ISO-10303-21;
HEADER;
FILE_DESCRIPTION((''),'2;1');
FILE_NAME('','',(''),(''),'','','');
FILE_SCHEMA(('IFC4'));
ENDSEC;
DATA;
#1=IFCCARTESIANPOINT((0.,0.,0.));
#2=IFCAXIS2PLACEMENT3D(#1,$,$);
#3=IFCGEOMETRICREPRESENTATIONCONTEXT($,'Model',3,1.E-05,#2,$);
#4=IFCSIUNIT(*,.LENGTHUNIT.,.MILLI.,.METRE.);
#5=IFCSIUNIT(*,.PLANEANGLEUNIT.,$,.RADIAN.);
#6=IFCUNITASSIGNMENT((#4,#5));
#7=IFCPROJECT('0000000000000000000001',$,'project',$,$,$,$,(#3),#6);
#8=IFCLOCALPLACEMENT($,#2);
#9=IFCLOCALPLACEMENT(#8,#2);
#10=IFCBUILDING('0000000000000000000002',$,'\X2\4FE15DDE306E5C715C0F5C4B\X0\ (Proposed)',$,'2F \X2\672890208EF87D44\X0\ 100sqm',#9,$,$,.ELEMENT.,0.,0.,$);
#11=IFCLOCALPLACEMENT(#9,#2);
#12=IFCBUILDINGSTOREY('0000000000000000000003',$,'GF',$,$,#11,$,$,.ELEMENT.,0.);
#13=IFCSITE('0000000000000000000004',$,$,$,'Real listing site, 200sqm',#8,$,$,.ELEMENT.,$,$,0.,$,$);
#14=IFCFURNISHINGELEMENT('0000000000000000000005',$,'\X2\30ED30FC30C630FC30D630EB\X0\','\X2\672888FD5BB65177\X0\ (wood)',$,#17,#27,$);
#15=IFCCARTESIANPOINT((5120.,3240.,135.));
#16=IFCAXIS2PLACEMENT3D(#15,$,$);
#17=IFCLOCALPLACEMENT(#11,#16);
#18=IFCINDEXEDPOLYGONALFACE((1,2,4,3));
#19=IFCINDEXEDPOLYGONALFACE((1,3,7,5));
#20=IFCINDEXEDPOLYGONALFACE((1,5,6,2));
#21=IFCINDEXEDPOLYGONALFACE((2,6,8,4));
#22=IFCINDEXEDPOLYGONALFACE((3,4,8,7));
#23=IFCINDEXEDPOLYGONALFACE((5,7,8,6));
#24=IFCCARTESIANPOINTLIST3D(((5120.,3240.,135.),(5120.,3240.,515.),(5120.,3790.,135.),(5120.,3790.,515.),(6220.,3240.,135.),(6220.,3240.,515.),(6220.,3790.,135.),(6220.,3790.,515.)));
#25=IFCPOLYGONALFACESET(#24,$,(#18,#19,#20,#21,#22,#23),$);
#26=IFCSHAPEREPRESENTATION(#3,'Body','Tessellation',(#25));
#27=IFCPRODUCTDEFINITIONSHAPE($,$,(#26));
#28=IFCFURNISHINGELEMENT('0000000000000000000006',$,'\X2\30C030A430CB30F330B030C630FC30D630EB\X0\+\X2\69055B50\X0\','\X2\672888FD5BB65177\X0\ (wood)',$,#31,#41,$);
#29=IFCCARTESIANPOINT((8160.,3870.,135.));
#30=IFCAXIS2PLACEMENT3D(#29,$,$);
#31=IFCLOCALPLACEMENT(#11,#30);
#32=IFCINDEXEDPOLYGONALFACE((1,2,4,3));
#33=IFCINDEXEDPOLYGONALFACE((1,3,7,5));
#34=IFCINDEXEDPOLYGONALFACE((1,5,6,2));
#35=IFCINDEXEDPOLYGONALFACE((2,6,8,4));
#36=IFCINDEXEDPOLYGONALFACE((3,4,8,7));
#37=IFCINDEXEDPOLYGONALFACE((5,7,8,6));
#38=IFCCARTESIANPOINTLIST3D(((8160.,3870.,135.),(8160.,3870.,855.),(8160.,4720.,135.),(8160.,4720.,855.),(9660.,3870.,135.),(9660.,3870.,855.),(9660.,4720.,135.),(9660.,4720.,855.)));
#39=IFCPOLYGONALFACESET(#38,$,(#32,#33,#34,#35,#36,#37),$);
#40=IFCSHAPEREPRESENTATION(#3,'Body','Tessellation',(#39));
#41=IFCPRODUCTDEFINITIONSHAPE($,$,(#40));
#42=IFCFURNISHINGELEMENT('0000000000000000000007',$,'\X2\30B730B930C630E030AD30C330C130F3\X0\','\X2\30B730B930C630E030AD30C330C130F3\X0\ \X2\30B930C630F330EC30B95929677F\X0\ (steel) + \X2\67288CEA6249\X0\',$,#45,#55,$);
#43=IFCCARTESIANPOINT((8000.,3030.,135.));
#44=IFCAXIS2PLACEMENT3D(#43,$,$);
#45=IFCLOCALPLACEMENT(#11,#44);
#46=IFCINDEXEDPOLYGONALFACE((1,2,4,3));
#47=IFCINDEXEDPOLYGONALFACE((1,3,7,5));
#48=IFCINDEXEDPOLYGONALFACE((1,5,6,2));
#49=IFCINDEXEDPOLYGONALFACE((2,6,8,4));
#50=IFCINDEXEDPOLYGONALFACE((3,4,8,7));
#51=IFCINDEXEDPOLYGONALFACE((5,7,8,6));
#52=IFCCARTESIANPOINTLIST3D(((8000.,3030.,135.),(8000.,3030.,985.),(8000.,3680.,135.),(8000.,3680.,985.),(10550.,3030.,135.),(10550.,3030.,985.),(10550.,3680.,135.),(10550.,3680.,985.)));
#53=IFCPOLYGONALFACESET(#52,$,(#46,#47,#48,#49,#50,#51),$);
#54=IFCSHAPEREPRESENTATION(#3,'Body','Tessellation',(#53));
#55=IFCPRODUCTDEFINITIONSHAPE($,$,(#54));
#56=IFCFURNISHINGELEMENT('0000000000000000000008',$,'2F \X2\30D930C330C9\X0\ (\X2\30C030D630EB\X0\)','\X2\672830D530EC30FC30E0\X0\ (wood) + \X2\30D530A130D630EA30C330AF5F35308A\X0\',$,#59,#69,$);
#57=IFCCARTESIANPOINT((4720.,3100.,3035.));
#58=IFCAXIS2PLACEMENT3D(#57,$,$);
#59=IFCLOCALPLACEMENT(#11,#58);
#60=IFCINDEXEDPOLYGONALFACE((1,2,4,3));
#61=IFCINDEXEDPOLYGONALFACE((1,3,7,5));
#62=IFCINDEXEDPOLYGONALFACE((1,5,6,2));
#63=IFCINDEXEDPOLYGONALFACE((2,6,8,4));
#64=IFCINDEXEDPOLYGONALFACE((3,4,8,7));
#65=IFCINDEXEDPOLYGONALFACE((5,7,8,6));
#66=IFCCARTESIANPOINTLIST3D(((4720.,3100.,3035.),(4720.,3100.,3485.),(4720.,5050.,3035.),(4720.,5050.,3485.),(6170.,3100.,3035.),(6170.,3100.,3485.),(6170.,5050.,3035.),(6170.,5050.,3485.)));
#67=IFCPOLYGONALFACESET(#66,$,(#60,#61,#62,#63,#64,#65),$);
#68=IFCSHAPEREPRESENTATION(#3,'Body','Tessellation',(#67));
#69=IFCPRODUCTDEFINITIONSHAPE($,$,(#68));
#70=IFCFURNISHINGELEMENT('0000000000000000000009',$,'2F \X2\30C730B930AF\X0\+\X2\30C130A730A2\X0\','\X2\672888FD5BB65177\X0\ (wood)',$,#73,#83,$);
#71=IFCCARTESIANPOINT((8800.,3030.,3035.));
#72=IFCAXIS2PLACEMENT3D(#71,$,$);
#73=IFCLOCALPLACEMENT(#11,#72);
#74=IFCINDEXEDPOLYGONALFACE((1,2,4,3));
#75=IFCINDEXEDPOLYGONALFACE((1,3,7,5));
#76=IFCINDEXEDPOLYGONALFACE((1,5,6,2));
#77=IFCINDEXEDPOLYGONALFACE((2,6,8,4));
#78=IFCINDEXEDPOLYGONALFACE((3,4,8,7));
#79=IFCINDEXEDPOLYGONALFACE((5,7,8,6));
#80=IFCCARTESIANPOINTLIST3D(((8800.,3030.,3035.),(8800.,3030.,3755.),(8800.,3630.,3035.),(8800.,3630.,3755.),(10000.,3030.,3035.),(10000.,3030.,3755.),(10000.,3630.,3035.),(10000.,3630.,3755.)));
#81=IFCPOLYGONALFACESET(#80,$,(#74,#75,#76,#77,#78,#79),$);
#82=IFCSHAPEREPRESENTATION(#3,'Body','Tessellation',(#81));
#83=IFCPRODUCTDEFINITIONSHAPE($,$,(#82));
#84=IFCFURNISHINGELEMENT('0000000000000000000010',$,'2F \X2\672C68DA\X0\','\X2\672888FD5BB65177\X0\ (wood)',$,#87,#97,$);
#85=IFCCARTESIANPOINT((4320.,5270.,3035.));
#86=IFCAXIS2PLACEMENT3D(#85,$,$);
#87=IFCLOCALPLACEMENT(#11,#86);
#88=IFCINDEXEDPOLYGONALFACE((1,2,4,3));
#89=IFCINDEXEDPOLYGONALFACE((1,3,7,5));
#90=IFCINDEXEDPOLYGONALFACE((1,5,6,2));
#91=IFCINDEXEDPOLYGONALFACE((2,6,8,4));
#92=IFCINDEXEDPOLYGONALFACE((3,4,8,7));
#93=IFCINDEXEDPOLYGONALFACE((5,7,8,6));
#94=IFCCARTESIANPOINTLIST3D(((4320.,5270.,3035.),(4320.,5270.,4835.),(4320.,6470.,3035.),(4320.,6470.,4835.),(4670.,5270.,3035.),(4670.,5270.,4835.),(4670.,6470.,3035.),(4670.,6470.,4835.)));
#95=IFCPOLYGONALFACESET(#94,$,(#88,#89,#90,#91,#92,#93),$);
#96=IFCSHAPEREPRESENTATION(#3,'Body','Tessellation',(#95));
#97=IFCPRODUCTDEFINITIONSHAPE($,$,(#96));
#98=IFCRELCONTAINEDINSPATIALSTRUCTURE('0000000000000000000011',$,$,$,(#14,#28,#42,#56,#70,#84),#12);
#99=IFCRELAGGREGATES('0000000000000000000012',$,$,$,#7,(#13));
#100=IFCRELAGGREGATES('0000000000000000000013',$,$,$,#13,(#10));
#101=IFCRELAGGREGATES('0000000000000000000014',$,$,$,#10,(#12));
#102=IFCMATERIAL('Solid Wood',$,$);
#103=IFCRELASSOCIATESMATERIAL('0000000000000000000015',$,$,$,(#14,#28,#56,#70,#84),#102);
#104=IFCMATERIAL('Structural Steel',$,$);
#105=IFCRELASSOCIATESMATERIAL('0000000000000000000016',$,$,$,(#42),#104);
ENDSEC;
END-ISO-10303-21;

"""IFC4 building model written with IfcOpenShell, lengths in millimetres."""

from ifc_helpers import new_model, si_unit, frame, frame_2d, origin, place, context, project, spatial, rectangle, extrude, material, element, save


model = new_model("IFC4")

# Units and contexts
model_context = context("Model", 3, precision=1e-05, world=origin())
ifc_project = project(units=[si_unit("LENGTHUNIT", "METRE", prefix="MILLI"), si_unit("PLANEANGLEUNIT", "RADIAN")], contexts=[model_context])

# Site, building, storey
site_placement = place(None, origin())
site = spatial("IfcSite", under=ifc_project, at=site_placement, ObjectType="Real listing site, 200sqm", CompositionType="ELEMENT", RefElevation=0.0)
building_placement = place(site_placement, origin())
building = spatial("IfcBuilding", under=site, at=building_placement, Name="信州の山小屋 (Proposed)", ObjectType="2F 木造軸組 100sqm", CompositionType="ELEMENT", ElevationOfRefHeight=0.0, ElevationOfTerrain=0.0)
storey_placement = place(building_placement, origin())
storey = spatial("IfcBuildingStorey", under=building, at=storey_placement, Name="GF", CompositionType="ELEMENT", Elevation=0.0)

# Shared definitions
ifc_material_1 = material(Name="Solid Wood")

# Shared definitions
ifc_material_2 = material(Name="Structural Steel")

# Furnishing elements
furnishing_1_placement = place(storey_placement, frame((5120.0, 3240.0, 135.0)))
element("IfcFurnishingElement", 1, at=furnishing_1_placement, inside=storey, material=ifc_material_1, Name="ローテーブル", Description="木製家具 (wood)", context=model_context, shape_type="SweptSolid", body=[
    extrude(rectangle(XDim=1100.0, YDim=550.0, at=frame_2d((550.0, 275.0))), frame((5120.0, 3240.0, 135.0)), (0.0, 0.0, 1.0), 380.0),
])
furnishing_2_placement = place(storey_placement, frame((8160.0, 3870.0, 135.0)))
element("IfcFurnishingElement", 2, at=furnishing_2_placement, inside=storey, material=ifc_material_1, Name="ダイニングテーブル+椅子", Description="木製家具 (wood)", context=model_context, shape_type="SweptSolid", body=[
    extrude(rectangle(XDim=1500.0, YDim=850.0, at=frame_2d((750.0, 425.0))), frame((8160.0, 3870.0, 135.0)), (0.0, 0.0, 1.0), 720.0),
])
furnishing_3_placement = place(storey_placement, frame((8000.0, 3030.0, 135.0)))
element("IfcFurnishingElement", 3, at=furnishing_3_placement, inside=storey, material=ifc_material_2, Name="システムキッチン", Description="システムキッチン ステンレス天板 (steel) + 木質扉", context=model_context, shape_type="SweptSolid", body=[
    extrude(rectangle(XDim=2550.0, YDim=650.0, at=frame_2d((1275.0, 325.0))), frame((8000.0, 3030.0, 135.0)), (0.0, 0.0, 1.0), 850.0),
])
furnishing_4_placement = place(storey_placement, frame((4720.0, 3100.0, 3035.0)))
element("IfcFurnishingElement", 4, at=furnishing_4_placement, inside=storey, material=ifc_material_1, Name="2F ベッド (ダブル)", Description="木フレーム (wood) + ファブリック張り", context=model_context, shape_type="SweptSolid", body=[
    extrude(rectangle(XDim=1450.0, YDim=1950.0, at=frame_2d((725.0, 975.0))), frame((4720.0, 3100.0, 3035.0)), (0.0, 0.0, 1.0), 450.0),
])
furnishing_5_placement = place(storey_placement, frame((8800.0, 3030.0, 3035.0)))
element("IfcFurnishingElement", 5, at=furnishing_5_placement, inside=storey, material=ifc_material_1, Name="2F デスク+チェア", Description="木製家具 (wood)", context=model_context, shape_type="SweptSolid", body=[
    extrude(rectangle(XDim=1200.0, YDim=600.0, at=frame_2d((600.0, 300.0))), frame((8800.0, 3030.0, 3035.0)), (0.0, 0.0, 1.0), 720.0),
])
furnishing_6_placement = place(storey_placement, frame((4320.0, 5270.0, 3035.0)))
element("IfcFurnishingElement", 6, at=furnishing_6_placement, inside=storey, material=ifc_material_1, Name="2F 本棚", Description="木製家具 (wood)", context=model_context, shape_type="SweptSolid", body=[
    extrude(rectangle(XDim=350.0, YDim=1200.0, at=frame_2d((175.0, 600.0))), frame((4320.0, 5270.0, 3035.0)), (0.0, 0.0, 1.0), 1800.0),
])

save(model, "model.ifc")
